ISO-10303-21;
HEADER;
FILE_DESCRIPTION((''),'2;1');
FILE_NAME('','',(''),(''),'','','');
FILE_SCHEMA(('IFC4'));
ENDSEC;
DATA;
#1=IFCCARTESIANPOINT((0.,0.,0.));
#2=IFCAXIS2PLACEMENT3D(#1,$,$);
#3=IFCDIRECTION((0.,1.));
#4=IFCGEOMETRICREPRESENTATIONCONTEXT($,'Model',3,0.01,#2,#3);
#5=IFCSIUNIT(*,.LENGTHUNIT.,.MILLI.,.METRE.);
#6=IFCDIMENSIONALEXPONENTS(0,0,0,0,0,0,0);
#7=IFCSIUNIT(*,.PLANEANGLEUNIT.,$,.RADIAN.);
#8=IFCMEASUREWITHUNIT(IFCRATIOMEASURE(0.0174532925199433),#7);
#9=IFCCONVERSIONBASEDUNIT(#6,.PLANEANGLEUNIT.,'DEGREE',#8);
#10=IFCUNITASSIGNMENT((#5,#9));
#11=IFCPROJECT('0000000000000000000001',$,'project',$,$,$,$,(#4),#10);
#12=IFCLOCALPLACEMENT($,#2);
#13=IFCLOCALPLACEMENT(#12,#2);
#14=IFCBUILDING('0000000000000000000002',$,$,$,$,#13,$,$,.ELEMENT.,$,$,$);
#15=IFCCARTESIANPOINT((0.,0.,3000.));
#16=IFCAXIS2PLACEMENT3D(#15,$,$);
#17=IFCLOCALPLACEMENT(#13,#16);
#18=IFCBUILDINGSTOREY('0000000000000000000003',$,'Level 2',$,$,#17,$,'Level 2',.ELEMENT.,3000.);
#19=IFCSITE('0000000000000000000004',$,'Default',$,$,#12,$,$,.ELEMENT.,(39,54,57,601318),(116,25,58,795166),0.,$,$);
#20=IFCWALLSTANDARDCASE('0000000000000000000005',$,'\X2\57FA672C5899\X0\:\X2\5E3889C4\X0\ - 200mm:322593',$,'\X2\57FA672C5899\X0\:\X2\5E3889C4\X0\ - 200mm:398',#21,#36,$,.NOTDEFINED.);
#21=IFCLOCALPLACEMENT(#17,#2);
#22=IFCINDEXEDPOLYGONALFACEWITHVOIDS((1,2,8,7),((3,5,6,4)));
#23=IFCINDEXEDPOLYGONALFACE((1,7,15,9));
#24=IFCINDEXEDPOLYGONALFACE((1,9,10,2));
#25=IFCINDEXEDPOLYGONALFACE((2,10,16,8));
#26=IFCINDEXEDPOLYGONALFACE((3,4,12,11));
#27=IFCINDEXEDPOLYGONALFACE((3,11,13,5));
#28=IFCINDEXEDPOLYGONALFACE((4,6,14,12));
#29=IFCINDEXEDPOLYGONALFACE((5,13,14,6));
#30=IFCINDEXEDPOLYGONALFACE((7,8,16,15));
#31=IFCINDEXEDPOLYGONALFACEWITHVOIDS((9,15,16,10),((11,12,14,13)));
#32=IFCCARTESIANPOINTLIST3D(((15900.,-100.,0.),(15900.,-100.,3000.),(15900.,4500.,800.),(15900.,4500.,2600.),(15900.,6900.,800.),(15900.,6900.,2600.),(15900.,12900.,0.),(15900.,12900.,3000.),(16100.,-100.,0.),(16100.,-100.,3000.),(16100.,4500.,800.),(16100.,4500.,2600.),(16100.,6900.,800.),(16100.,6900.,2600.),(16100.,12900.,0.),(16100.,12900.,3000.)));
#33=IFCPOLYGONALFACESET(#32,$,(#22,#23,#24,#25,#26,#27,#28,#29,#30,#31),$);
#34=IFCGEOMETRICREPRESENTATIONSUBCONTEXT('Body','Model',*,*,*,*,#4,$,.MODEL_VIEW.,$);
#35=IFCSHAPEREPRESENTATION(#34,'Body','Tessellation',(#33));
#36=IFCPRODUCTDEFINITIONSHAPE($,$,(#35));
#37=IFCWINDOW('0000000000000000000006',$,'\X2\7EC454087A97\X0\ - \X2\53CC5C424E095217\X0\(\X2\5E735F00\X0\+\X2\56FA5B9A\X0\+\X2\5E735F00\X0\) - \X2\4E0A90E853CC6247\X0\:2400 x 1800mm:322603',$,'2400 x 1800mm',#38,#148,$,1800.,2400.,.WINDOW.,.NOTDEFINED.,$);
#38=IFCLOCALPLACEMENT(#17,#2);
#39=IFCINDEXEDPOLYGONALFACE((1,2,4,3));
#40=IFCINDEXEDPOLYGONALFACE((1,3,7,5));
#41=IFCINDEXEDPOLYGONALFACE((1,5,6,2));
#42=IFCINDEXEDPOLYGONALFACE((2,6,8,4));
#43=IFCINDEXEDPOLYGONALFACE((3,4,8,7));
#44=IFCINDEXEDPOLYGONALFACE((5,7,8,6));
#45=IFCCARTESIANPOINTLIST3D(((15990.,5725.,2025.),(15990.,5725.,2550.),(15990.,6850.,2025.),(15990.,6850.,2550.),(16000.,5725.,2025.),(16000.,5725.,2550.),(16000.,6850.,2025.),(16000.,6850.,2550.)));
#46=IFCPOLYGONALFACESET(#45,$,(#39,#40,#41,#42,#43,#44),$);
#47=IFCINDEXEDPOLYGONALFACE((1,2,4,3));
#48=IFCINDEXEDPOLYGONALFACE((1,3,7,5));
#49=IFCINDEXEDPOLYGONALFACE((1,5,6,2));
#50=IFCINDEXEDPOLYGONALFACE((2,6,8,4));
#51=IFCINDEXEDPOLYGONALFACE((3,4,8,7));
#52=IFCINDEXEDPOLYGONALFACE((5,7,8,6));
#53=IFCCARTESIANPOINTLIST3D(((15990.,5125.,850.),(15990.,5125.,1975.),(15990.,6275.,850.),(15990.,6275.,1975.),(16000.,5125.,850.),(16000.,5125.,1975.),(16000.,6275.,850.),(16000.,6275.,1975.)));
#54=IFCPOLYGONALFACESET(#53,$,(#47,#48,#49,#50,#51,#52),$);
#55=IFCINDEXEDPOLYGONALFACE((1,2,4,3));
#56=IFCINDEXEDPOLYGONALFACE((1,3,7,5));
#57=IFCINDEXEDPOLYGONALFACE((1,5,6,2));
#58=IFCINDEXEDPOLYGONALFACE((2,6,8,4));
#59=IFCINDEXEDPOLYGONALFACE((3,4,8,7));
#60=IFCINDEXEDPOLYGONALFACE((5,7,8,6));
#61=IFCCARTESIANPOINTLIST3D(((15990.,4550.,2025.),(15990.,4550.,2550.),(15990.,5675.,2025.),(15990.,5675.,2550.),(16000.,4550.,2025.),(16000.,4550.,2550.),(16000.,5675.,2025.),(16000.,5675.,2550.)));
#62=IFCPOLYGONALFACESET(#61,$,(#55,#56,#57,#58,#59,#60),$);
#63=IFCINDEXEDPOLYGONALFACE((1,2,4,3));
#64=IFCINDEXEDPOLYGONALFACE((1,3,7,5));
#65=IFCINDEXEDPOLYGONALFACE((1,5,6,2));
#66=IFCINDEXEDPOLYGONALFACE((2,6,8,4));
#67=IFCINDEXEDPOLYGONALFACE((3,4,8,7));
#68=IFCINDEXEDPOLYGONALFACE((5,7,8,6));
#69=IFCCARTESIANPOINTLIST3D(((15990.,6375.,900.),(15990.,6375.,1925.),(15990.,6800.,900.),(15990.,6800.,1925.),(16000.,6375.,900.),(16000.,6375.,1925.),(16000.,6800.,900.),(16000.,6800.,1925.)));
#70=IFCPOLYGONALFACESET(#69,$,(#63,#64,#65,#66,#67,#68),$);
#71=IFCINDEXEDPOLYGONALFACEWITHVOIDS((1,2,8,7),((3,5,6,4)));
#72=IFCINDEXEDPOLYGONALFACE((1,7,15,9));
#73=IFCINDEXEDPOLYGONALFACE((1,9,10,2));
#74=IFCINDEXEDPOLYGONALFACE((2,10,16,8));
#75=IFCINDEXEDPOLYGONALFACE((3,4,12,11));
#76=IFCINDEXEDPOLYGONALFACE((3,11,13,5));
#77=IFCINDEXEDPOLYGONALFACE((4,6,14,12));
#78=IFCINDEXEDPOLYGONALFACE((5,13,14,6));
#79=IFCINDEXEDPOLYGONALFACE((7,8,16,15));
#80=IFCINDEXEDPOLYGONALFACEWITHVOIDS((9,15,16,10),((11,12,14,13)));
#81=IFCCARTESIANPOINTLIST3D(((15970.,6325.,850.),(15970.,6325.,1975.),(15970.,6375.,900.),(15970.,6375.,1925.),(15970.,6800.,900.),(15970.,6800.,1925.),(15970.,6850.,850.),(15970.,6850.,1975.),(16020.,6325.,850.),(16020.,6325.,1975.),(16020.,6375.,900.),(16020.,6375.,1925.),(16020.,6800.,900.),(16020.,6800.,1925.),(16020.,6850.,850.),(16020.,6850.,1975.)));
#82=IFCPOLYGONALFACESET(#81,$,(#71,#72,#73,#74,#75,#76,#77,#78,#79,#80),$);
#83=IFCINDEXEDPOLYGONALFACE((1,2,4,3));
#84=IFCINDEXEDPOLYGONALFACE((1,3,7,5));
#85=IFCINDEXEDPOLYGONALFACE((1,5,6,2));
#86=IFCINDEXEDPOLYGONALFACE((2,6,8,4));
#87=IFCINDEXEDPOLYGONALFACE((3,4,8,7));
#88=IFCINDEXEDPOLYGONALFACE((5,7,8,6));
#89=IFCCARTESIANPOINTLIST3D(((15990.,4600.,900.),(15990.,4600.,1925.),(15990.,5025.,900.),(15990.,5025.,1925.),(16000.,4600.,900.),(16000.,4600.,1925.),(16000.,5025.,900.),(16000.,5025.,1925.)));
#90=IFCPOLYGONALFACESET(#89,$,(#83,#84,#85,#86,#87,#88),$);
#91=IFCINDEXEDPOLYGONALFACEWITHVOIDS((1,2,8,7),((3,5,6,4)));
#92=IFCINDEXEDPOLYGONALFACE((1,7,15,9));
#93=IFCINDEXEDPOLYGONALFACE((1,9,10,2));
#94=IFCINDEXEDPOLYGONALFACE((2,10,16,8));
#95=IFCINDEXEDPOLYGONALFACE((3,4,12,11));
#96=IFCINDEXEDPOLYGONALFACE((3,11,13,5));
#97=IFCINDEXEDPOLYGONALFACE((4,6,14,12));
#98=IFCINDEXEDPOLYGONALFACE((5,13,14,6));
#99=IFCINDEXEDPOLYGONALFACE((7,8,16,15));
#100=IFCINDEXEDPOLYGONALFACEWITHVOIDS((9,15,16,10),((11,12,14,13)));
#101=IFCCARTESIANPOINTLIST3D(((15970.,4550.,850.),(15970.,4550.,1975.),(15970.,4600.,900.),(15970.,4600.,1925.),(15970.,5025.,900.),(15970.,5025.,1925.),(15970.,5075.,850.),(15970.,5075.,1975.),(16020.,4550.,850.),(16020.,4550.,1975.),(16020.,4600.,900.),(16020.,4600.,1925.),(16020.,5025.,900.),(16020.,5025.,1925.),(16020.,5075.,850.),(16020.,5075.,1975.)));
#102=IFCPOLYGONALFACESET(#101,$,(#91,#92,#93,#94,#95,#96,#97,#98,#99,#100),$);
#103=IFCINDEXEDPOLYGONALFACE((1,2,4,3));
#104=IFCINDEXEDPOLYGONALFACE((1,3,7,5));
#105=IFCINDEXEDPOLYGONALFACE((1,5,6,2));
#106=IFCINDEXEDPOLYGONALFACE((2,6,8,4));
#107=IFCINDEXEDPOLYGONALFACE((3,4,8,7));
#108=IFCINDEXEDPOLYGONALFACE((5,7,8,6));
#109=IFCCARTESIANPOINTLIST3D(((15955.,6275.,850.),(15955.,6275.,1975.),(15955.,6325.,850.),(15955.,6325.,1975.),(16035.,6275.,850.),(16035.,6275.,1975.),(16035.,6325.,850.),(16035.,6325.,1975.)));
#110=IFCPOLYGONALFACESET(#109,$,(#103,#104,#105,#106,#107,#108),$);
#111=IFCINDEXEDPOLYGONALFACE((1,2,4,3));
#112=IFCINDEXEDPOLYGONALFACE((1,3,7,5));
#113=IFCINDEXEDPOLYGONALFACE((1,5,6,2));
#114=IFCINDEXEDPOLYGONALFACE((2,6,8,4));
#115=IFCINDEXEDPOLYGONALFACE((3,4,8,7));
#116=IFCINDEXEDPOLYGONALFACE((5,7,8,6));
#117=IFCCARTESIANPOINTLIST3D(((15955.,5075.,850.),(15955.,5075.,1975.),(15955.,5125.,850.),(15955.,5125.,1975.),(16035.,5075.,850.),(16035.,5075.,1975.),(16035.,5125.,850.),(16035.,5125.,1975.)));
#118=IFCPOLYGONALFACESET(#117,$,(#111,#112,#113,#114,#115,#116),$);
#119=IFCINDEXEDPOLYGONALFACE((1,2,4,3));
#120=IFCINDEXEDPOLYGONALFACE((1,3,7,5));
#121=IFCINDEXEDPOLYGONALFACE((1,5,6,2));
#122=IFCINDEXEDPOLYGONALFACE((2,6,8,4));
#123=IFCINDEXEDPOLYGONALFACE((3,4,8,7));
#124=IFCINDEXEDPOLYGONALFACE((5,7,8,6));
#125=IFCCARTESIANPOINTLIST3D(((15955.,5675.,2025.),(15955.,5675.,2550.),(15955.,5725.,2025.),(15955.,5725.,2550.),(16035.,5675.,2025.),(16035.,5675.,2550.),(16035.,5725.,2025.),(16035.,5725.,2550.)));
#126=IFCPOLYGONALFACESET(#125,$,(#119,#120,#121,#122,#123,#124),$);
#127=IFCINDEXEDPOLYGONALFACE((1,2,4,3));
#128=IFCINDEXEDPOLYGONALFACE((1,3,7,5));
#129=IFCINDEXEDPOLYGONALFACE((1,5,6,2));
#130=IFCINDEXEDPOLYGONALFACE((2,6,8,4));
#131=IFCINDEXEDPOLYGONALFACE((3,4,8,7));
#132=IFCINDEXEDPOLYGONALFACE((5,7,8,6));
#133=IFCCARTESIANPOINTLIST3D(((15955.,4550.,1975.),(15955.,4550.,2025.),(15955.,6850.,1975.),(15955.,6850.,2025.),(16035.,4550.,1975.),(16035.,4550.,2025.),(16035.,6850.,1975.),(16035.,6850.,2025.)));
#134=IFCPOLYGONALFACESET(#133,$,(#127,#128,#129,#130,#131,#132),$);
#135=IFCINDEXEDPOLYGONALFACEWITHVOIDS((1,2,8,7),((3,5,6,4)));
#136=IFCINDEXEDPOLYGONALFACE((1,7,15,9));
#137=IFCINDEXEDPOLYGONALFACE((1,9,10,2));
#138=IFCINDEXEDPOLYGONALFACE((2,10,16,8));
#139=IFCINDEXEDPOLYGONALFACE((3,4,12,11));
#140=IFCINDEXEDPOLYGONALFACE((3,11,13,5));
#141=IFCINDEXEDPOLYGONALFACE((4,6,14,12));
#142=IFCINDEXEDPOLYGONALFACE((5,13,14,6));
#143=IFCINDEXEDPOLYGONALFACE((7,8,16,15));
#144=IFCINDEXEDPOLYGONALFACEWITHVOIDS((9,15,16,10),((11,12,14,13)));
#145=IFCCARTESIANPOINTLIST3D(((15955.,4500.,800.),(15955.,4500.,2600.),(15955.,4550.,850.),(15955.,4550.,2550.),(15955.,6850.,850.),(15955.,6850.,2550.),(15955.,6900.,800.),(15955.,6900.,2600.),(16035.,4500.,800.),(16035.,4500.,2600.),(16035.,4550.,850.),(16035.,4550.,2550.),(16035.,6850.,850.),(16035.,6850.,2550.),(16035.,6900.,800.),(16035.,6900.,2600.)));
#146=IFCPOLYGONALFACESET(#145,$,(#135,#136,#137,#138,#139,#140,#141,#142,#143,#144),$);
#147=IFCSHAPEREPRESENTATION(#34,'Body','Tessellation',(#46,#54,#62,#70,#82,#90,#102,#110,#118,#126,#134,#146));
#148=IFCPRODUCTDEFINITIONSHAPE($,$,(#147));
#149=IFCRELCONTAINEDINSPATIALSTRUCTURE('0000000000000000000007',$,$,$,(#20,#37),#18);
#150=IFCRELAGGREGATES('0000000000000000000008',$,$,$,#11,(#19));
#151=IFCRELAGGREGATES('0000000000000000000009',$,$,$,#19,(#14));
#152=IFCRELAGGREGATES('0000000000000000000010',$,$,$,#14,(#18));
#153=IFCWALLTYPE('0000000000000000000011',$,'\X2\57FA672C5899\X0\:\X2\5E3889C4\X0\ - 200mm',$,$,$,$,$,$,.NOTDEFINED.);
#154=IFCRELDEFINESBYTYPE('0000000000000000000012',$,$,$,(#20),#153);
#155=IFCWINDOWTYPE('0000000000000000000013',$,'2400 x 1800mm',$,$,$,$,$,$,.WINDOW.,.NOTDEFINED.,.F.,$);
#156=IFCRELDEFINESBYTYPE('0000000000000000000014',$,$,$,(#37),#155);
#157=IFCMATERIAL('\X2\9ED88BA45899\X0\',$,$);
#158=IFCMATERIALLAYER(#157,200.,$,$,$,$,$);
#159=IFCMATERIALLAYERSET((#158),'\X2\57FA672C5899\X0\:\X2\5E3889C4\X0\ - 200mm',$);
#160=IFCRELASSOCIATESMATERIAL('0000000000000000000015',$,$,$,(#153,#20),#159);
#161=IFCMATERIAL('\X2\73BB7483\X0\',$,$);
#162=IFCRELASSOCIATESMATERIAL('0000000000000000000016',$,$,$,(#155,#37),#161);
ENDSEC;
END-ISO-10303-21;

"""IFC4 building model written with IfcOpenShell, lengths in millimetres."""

from ifc_helpers import new_model, entity, si_unit, converted_unit, direction, frame, frame_2d, origin, origin_2d_with_axis, place, context, subcontext, project, spatial, polyline, rectangle, outline, extrude, source, transform, mapped, material, layer, layer_set, layer_usage, type_object, type_shapes, element, fill, save


model = new_model("IFC4")

# Units and contexts
model_context = context("Model", 3, precision=0.01, world=origin(), true_north=direction((0.0, 1.0)))
body_context = subcontext(model_context, "Body", "Model", "MODEL_VIEW")
ifc_project = project(units=[si_unit("LENGTHUNIT", "METRE", prefix="MILLI"), converted_unit("PLANEANGLEUNIT", "DEGREE", entity("IfcRatioMeasure", 0.0174532925199433), si_unit("PLANEANGLEUNIT", "RADIAN"), dimensions=[0, 0, 0, 0, 0, 0, 0])], contexts=[model_context])

# Site, building, storey
site_placement = place(None, origin())
site = spatial("IfcSite", under=ifc_project, at=site_placement, Name="Default", CompositionType="ELEMENT", RefLatitude=(39, 54, 57, 601318), RefLongitude=(116, 25, 58, 795166), RefElevation=0.0)
building_placement = place(site_placement, origin())
building = spatial("IfcBuilding", under=site, at=building_placement, CompositionType="ELEMENT")
storey_placement = place(building_placement, frame((0.0, 0.0, 3000.0)))
storey = spatial("IfcBuildingStorey", under=building, at=storey_placement, Name="Level 2", LongName="Level 2", CompositionType="ELEMENT", Elevation=3000.0)

# Shared definitions
ifc_material_1 = material(Name="默认墙")
ifc_layer_1 = layer(ifc_material_1, 200.0)
ifc_layer_set_1 = layer_set([ifc_layer_1], Name="基本墙:常规 - 200mm")
wall_type = type_object("IfcWallType", Name="基本墙:常规 - 200mm", PredefinedType="NOTDEFINED", material=ifc_layer_set_1)

# Shared definitions
ifc_material_2 = material(Name="玻璃")

# Wall, opening, window
ifc_layer_usage_1 = layer_usage(ifc_layer_set_1, "AXIS2", "NEGATIVE", 100.0)
wall_1_placement = place(storey_placement, frame((16000.0, 12900.0, 0.0), z_axis=(0.0, 0.0, 1.0), x_axis=(0.0, -1.0, 0.0)))
wall_1 = element("IfcWallStandardCase", 1, at=wall_1_placement, inside=storey, type_object=wall_type, material=ifc_layer_usage_1, Name="基本墙:常规 - 200mm:322593", ObjectType="基本墙:常规 - 200mm:398", PredefinedType="NOTDEFINED", context=body_context, shape_type="SweptSolid", body=[
    extrude(rectangle(XDim=13000.0, YDim=200.0, at=frame_2d((6500.0, 0.0), x_axis=(-1.0, 0.0))), origin(), (0.0, 0.0, 1.0), 3000.0),
])
opening_1_placement = place(wall_1_placement, frame((6000.0, -100.0, 800.0)))
opening_1 = element("IfcOpeningElement", 2, at=opening_1_placement, cuts=wall_1, ObjectType="Opening", PredefinedType="OPENING", context=body_context, shape_type="SweptSolid", body=[
    extrude(rectangle(XDim=1800.0, YDim=2400.0, at=frame_2d((900.0, 1200.0), x_axis=(1.0, 0.0))), frame((0.0, 0.0, 0.0), z_axis=(0.0, 1.0, 0.0), x_axis=(0.0, 0.0, 1.0)), (0.0, 0.0, 1.0), 200.0),
])
window_type_1 = type_object("IfcWindowType", Name="2400 x 1800mm", ParameterTakesPrecedence=False, PartitioningType="NOTDEFINED", PredefinedType="WINDOW", material=ifc_material_2)
shared_shape_1 = source(origin(), body_context, "Body", "SweptSolid", [
    extrude(rectangle(XDim=10.0, YDim=1125.0, at=origin_2d_with_axis()), frame((612.5, 95.0, 1225.0), z_axis=(0.0, 0.0, 1.0), x_axis=(0.0, 1.0, 0.0)), (0.0, 0.0, 1.0), 525.0),
    extrude(rectangle(XDim=10.0, YDim=1150.0, at=origin_2d_with_axis()), frame((1200.0, 95.0, 50.0), z_axis=(0.0, 0.0, 1.0), x_axis=(0.0, 1.0, 0.0)), (0.0, 0.0, 1.0), 1125.0),
    extrude(rectangle(XDim=10.0, YDim=1125.0, at=origin_2d_with_axis()), frame((1787.5, 95.0, 1225.0), z_axis=(0.0, 0.0, 1.0), x_axis=(0.0, 1.0, 0.0)), (0.0, 0.0, 1.0), 525.0),
    extrude(rectangle(XDim=10.0, YDim=425.0, at=origin_2d_with_axis()), frame((312.5, 95.0, 100.0), z_axis=(0.0, 0.0, 1.0), x_axis=(0.0, 1.0, 0.0)), (0.0, 0.0, 1.0), 1025.0),
    extrude(outline(polyline([(-562.5, -262.5), (562.5, -262.5), (562.5, 262.5), (-562.5, 262.5), (-562.5, -262.5)]), holes=[polyline([(512.5, -212.5), (-512.5, -212.5), (-512.5, 212.5), (512.5, 212.5), (512.5, -212.5)])]), frame((312.5, 70.0, 612.5), z_axis=(0.0, 1.0, 0.0), x_axis=(0.0, 0.0, -1.0)), (0.0, 0.0, 1.0), 50.0),
    extrude(rectangle(XDim=10.0, YDim=425.0, at=origin_2d_with_axis()), frame((2087.5, 95.0, 100.0), z_axis=(0.0, 0.0, 1.0), x_axis=(0.0, 1.0, 0.0)), (0.0, 0.0, 1.0), 1025.0),
    extrude(outline(polyline([(-562.5, -262.5), (562.5, -262.5), (562.5, 262.5), (-562.5, 262.5), (-562.5, -262.5)]), holes=[polyline([(512.5, -212.5), (-512.5, -212.5), (-512.5, 212.5), (512.5, 212.5), (512.5, -212.5)])]), frame((2087.5, 70.0, 612.5), z_axis=(0.0, 1.0, 0.0), x_axis=(0.0, 0.0, -1.0)), (0.0, 0.0, 1.0), 50.0),
    extrude(rectangle(XDim=80.0, YDim=50.0, at=origin_2d_with_axis()), frame((600.0, 95.0, 50.0), z_axis=(0.0, 0.0, 1.0), x_axis=(0.0, -1.0, 0.0)), (0.0, 0.0, 1.0), 1125.0),
    extrude(rectangle(XDim=80.0, YDim=50.0, at=origin_2d_with_axis()), frame((1800.0, 95.0, 50.0), z_axis=(0.0, 0.0, 1.0), x_axis=(0.0, -1.0, 0.0)), (0.0, 0.0, 1.0), 1125.0),
    extrude(rectangle(XDim=80.0, YDim=50.0, at=origin_2d_with_axis()), frame((1200.0, 95.0, 1225.0), z_axis=(0.0, 0.0, 1.0), x_axis=(0.0, -1.0, 0.0)), (0.0, 0.0, 1.0), 525.0),
    extrude(rectangle(XDim=80.0, YDim=2300.0, at=origin_2d_with_axis()), frame((1200.0, 95.0, 1175.0), z_axis=(0.0, 0.0, 1.0), x_axis=(0.0, -1.0, 0.0)), (0.0, 0.0, 1.0), 50.0),
    extrude(outline(polyline([(-1200.0, -900.0), (1200.0, -900.0), (1200.0, 900.0), (-1200.0, 900.0), (-1200.0, -900.0)]), holes=[polyline([(1150.0, -850.0), (-1150.0, -850.0), (-1150.0, 850.0), (1150.0, 850.0), (1150.0, -850.0)])]), frame((1200.0, 55.0, 900.0), z_axis=(0.0, 1.0, 0.0), x_axis=(1.0, 0.0, 0.0)), (0.0, 0.0, 1.0), 80.0),
])
type_shapes(window_type_1, [shared_shape_1])
window_1_placement = place(opening_1_placement, origin())
window_1 = element("IfcWindow", 3, at=window_1_placement, inside=storey, type_object=window_type_1, material=ifc_material_2, Name="组合窗 - 双层三列(平开+固定+平开) - 上部双扇:2400 x 1800mm:322603", ObjectType="2400 x 1800mm", OverallHeight=1800.0, OverallWidth=2400.0, PartitioningType="NOTDEFINED", PredefinedType="WINDOW", context=body_context, shape_type="MappedRepresentation", body=[
    mapped(shared_shape_1, transform((0.0, 0.0, 0.0), scale=1.0)),
])
fill(opening_1, window_1)

save(model, "model.ifc")
